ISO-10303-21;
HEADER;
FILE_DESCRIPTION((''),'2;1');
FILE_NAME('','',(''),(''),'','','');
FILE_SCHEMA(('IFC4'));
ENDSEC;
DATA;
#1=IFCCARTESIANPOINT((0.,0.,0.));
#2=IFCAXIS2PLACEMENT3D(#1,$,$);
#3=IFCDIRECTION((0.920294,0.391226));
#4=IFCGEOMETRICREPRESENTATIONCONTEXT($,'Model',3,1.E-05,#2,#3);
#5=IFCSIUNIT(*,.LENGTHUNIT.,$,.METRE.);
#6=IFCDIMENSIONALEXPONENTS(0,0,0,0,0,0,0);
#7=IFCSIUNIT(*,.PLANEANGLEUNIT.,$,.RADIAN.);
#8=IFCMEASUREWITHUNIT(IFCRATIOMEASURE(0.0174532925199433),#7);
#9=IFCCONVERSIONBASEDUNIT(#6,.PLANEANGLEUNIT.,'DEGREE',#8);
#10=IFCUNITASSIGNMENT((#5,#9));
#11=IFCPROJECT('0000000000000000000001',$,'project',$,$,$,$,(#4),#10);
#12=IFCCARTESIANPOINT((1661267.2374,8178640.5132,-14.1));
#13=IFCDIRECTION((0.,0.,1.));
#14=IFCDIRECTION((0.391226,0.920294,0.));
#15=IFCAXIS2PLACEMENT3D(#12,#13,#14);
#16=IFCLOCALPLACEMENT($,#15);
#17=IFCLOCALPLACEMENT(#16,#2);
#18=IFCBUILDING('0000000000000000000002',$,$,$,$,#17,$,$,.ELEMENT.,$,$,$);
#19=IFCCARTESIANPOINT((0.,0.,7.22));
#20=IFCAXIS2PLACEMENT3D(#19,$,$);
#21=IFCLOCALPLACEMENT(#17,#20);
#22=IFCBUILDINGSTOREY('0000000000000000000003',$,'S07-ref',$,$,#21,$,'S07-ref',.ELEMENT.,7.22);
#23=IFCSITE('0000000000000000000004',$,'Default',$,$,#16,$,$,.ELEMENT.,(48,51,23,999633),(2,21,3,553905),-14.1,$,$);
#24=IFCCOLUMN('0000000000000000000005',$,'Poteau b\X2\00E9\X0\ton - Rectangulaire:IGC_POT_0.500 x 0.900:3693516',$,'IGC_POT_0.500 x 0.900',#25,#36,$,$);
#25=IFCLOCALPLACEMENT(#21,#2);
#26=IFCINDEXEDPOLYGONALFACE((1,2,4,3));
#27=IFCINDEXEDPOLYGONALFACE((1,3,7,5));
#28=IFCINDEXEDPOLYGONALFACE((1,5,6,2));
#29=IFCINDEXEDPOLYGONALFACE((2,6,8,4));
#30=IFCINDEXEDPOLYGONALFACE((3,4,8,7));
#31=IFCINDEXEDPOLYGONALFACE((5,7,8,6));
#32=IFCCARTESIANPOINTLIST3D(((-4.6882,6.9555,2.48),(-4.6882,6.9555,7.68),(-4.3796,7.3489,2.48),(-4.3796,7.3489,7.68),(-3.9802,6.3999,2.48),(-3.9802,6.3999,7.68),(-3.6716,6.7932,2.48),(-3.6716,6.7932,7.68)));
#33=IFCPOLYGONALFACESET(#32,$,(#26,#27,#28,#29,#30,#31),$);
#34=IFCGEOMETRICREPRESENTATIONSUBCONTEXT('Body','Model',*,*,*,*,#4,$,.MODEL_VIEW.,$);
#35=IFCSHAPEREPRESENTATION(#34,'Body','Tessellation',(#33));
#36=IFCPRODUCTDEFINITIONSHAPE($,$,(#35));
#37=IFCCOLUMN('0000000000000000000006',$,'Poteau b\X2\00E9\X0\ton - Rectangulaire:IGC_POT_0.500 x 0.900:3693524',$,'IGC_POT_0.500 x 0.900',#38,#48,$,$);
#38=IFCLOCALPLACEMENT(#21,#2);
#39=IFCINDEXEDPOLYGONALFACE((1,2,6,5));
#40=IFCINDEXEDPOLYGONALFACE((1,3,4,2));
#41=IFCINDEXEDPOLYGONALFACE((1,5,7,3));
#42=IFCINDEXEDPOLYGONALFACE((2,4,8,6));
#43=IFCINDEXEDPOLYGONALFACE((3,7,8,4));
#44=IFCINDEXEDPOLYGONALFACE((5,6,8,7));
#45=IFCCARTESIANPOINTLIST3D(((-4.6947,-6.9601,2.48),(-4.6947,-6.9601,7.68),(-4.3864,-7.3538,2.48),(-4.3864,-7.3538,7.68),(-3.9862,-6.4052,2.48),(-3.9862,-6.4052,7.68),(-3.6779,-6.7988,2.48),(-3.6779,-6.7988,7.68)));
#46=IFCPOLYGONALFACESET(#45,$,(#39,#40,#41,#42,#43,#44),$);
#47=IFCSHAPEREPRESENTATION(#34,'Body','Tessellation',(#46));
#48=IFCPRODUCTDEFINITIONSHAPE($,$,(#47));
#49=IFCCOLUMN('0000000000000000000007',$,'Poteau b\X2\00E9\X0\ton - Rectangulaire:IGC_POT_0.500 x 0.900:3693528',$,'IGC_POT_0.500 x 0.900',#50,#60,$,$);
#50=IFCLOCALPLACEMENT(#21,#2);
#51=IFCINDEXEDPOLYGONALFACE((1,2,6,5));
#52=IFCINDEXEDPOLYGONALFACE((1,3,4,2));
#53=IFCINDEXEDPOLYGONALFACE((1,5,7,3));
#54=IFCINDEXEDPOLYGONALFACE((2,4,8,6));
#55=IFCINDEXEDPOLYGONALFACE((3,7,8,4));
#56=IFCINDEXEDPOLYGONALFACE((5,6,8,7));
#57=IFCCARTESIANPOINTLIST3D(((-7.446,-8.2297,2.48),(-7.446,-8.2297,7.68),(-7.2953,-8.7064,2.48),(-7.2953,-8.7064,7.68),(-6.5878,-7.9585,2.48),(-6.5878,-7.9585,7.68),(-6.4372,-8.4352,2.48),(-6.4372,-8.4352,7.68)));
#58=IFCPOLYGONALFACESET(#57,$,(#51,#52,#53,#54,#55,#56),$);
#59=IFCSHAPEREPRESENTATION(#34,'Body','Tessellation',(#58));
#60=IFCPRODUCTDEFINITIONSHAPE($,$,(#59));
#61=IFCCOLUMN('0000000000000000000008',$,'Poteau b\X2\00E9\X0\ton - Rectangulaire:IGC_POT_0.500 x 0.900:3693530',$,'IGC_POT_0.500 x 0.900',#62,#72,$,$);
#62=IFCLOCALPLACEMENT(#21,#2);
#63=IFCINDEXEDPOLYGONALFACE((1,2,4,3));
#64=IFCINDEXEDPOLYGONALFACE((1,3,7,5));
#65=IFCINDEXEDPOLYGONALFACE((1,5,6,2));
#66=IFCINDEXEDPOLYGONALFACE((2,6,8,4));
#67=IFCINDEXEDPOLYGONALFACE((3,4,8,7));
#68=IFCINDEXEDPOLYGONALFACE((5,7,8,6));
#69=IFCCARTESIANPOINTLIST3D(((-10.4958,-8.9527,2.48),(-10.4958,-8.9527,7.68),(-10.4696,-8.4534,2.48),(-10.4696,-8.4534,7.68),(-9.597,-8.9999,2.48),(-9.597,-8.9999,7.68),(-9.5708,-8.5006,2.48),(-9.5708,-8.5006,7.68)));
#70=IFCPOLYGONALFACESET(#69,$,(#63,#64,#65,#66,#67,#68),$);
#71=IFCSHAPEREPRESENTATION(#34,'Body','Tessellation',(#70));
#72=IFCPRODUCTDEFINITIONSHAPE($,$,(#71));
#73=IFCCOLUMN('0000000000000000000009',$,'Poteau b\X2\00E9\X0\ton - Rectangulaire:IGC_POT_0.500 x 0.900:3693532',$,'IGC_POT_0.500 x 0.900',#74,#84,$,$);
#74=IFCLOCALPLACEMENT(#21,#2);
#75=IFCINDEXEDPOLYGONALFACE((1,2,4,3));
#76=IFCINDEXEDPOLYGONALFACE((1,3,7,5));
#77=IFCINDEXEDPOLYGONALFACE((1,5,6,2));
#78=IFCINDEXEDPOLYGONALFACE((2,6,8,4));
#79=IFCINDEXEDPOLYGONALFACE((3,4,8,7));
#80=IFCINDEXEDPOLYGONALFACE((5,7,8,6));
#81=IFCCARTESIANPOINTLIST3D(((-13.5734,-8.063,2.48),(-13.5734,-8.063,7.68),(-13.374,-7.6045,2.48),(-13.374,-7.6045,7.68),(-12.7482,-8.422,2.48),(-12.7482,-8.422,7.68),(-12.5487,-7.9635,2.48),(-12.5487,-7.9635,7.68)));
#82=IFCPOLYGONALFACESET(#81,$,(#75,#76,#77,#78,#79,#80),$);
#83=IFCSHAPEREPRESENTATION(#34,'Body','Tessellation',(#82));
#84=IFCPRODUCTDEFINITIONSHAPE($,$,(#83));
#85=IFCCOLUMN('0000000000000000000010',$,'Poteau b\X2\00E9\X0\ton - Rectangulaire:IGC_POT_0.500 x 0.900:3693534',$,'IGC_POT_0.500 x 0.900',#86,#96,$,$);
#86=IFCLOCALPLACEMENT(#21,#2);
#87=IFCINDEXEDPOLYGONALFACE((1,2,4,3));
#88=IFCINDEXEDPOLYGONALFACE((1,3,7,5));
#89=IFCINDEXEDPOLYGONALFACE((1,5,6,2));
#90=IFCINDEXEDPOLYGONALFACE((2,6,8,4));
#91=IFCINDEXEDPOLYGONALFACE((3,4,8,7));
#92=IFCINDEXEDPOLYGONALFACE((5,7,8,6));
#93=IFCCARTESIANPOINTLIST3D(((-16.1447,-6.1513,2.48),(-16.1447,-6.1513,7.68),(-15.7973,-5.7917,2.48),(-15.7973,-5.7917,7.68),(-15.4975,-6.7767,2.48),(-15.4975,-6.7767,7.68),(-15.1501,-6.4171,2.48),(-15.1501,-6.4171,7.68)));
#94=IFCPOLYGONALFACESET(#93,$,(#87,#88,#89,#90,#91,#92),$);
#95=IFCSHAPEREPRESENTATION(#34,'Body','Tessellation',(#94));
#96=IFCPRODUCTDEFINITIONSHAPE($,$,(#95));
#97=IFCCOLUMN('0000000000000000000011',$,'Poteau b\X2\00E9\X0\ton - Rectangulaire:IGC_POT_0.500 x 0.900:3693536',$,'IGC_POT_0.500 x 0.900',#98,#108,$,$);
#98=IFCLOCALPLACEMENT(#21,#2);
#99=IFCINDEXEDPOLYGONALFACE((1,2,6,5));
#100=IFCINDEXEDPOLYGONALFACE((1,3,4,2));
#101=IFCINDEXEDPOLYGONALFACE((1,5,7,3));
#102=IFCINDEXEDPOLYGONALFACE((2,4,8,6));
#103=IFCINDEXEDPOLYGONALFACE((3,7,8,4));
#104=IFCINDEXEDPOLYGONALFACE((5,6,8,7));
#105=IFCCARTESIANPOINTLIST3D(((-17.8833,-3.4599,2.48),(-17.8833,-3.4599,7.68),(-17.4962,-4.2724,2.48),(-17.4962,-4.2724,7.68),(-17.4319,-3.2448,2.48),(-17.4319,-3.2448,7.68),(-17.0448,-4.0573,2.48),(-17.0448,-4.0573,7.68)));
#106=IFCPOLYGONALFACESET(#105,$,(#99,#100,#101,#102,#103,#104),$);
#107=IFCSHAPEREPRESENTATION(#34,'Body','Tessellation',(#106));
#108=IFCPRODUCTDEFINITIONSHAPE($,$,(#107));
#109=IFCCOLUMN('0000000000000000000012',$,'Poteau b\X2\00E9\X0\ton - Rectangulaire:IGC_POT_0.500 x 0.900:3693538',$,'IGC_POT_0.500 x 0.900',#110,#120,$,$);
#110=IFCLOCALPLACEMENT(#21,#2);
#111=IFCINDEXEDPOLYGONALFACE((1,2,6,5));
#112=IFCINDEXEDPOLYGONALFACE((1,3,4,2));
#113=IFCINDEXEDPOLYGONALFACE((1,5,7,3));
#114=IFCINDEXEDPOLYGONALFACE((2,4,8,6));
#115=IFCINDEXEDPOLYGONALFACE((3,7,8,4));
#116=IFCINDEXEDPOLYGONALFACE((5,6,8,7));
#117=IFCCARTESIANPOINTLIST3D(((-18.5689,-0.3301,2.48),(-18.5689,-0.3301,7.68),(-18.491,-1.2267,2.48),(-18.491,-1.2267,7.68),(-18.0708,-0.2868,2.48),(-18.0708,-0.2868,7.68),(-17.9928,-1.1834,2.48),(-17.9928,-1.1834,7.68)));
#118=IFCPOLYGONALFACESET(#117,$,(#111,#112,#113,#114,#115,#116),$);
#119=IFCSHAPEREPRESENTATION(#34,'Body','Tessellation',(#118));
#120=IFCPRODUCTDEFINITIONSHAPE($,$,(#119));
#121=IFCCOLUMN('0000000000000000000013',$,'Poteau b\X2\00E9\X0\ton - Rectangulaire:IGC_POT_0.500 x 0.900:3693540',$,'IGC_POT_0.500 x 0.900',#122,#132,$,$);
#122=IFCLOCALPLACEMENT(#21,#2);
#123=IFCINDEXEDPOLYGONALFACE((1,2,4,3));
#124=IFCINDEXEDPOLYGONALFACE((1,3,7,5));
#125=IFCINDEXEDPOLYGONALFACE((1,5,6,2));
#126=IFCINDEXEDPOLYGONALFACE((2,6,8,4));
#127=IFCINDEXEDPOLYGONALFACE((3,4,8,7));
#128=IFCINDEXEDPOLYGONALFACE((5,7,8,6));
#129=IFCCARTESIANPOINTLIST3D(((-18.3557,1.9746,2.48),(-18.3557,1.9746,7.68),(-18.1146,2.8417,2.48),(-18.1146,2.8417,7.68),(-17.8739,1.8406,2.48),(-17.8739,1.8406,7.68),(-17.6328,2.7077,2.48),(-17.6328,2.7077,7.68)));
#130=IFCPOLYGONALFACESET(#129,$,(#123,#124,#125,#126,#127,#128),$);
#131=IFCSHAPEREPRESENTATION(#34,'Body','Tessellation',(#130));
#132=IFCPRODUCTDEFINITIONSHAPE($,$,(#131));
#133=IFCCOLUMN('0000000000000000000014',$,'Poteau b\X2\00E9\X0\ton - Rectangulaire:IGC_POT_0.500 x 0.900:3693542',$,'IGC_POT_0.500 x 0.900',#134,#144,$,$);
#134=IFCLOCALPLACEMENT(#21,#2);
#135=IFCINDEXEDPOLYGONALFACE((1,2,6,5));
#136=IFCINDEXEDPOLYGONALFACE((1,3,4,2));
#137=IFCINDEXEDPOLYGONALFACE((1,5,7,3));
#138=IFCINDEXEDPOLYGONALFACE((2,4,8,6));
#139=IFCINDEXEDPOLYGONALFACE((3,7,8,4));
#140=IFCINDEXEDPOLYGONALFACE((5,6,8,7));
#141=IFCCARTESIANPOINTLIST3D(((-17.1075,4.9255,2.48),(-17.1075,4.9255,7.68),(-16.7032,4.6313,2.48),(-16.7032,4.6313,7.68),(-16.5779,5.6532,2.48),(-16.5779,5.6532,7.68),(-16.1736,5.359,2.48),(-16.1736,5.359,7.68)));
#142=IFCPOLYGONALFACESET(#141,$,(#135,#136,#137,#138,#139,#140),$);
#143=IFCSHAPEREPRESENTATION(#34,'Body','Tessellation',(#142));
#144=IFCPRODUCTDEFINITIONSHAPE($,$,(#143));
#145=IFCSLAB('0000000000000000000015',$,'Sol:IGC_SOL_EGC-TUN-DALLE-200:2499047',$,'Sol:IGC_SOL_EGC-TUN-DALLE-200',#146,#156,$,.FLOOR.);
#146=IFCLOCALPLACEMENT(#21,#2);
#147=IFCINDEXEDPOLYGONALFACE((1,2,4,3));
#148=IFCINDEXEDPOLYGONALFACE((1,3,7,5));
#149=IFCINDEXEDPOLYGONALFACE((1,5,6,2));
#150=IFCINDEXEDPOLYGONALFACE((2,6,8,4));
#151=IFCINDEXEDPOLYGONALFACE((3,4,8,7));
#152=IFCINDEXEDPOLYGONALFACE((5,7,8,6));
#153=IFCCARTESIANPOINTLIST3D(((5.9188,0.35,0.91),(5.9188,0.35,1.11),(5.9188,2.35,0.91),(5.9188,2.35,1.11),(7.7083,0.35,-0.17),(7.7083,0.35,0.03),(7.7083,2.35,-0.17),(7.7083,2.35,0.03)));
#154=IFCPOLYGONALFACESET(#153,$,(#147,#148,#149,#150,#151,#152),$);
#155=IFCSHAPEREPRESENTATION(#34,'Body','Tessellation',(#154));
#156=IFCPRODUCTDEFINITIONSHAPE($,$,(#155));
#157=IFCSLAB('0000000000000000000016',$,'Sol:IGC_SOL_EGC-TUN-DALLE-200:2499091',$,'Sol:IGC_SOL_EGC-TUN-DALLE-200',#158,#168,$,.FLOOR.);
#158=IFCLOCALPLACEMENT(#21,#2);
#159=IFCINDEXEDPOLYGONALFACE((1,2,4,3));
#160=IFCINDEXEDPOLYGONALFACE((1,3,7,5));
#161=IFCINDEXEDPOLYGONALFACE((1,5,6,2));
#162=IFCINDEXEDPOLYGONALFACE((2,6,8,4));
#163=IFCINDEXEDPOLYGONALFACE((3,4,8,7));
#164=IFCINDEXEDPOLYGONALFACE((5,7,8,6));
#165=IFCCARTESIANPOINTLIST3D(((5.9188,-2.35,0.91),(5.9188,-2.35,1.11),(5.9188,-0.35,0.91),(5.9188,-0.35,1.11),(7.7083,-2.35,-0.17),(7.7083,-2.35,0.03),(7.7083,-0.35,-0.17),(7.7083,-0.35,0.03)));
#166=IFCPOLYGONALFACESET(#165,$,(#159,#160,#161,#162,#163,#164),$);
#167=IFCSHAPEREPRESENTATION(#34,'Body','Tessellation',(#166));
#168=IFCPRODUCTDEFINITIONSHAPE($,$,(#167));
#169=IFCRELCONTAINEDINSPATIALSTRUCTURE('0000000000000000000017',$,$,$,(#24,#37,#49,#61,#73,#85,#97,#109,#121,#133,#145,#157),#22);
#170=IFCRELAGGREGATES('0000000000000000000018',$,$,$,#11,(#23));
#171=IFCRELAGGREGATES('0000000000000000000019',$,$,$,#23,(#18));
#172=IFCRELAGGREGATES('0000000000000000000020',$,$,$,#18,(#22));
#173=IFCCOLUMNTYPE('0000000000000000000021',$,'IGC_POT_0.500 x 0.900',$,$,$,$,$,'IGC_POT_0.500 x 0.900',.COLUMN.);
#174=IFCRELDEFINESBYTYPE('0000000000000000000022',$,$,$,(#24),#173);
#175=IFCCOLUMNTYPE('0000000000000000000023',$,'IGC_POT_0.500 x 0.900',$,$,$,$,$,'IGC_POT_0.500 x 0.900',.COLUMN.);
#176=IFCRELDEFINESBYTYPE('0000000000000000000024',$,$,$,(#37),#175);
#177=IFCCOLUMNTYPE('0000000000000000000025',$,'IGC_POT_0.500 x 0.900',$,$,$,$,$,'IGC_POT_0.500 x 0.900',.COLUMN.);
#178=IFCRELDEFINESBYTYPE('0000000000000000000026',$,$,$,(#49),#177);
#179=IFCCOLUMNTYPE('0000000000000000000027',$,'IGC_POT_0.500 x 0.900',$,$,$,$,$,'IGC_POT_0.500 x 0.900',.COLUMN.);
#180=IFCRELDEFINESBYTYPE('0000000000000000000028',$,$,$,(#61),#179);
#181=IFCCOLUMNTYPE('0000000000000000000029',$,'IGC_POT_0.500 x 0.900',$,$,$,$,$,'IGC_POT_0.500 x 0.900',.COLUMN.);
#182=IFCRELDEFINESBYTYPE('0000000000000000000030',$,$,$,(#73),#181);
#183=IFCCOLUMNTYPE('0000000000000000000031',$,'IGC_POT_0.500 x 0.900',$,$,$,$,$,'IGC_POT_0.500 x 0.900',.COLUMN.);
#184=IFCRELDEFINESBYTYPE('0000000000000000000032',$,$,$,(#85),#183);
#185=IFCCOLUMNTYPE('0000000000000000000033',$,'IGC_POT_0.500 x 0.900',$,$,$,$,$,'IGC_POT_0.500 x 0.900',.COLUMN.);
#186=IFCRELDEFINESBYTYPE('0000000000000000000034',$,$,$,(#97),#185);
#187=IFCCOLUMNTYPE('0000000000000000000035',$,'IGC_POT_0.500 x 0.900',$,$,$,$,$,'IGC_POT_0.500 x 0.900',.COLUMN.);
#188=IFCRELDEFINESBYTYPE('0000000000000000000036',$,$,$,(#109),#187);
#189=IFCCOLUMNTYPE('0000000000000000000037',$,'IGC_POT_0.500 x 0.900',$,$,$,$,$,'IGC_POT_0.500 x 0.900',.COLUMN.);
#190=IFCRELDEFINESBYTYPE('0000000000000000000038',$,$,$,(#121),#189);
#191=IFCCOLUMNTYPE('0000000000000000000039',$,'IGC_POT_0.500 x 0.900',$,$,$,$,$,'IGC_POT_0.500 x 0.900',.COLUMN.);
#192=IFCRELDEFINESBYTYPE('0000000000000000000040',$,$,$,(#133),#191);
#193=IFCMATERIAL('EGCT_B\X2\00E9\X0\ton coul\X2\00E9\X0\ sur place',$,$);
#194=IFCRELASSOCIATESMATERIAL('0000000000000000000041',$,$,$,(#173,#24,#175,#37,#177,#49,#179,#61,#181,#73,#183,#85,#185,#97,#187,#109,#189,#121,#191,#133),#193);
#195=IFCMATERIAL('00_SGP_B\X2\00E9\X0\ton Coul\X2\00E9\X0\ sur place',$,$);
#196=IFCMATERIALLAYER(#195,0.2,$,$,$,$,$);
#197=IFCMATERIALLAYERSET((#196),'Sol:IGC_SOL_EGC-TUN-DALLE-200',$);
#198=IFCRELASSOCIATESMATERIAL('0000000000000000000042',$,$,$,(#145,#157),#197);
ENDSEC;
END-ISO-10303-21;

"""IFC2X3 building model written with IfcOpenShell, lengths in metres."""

from ifc_helpers import new_model, entity, si_unit, converted_unit, direction, frame, frame_2d, origin, origin_2d_with_axis, place, context, subcontext, project, spatial, polyline, rectangle, outline, extrude, source, transform, mapped, material, layer, layer_set, layer_usage, type_object, type_shapes, element, save


model = new_model("IFC2X3")

# Units and contexts
model_context = context("Model", 3, precision=1e-05, world=origin(), true_north=direction((0.920294, 0.391226)))
body_context = subcontext(model_context, "Body", "Model", "MODEL_VIEW")
ifc_project = project(units=[si_unit("LENGTHUNIT", "METRE"), converted_unit("PLANEANGLEUNIT", "DEGREE", entity("IfcRatioMeasure", 0.0174532925199433), si_unit("PLANEANGLEUNIT", "RADIAN"), dimensions=[0, 0, 0, 0, 0, 0, 0])], contexts=[model_context])

# Site, building, storey
site_placement = place(None, frame((1661267.2374, 8178640.5132, -14.1), z_axis=(0.0, 0.0, 1.0), x_axis=(0.391226, 0.920294, 0.0)))
site = spatial("IfcSite", under=ifc_project, at=site_placement, Name="Default", CompositionType="ELEMENT", RefLatitude=(48, 51, 23, 999633), RefLongitude=(2, 21, 3, 553905), RefElevation=-14.1)
building_placement = place(site_placement, origin())
building = spatial("IfcBuilding", under=site, at=building_placement, CompositionType="ELEMENT")
storey_placement = place(building_placement, frame((0.0, 0.0, 7.22)))
storey = spatial("IfcBuildingStorey", under=building, at=storey_placement, Name="S07-ref", LongName="S07-ref", CompositionType="ELEMENT", Elevation=7.22)

# Columns
ifc_material_1 = material(Name="EGCT_Béton coulé sur place")
column_type_1 = type_object("IfcColumnType", Name="IGC_POT_0.500 x 0.900", ElementType="IGC_POT_0.500 x 0.900", PredefinedType="COLUMN", material=ifc_material_1)
shared_shape_1 = source(origin(), body_context, "Body", "SweptSolid", [
    extrude(rectangle(XDim=0.9, YDim=0.5, at=frame_2d((0.0, 0.0), x_axis=(1.0, 0.0))), frame((-4.1799, 6.8744, 9.7), z_axis=(0.0, 0.0, 1.0), x_axis=(-0.786665, 0.617381, 0.0)), (0.0, 0.0, 1.0), 5.2),
])
type_shapes(column_type_1, [shared_shape_1])
column_1_placement = place(storey_placement, frame((0.0, 0.0, -7.22)))
element("IfcColumn", 1, at=column_1_placement, inside=storey, type_object=column_type_1, material=ifc_material_1, Name="Poteau béton - Rectangulaire:IGC_POT_0.500 x 0.900:3693516", ObjectType="IGC_POT_0.500 x 0.900", context=body_context, shape_type="MappedRepresentation", body=[
    mapped(shared_shape_1, transform((0.0, 0.0, 0.0), scale=1.0)),
])
column_type_2 = type_object("IfcColumnType", Name="IGC_POT_0.500 x 0.900", ElementType="IGC_POT_0.500 x 0.900", PredefinedType="COLUMN", material=ifc_material_1)
shared_shape_2 = source(origin(), body_context, "Body", "SweptSolid", [
    extrude(rectangle(XDim=0.9, YDim=0.5, at=origin_2d_with_axis()), frame((-4.1863, -6.8795, 9.7), z_axis=(0.0, 0.0, 1.0), x_axis=(0.787239, 0.616648, 0.0)), (0.0, 0.0, 1.0), 5.2),
])
type_shapes(column_type_2, [shared_shape_2])
column_2_placement = place(storey_placement, frame((0.0, 0.0, -7.22)))
element("IfcColumn", 2, at=column_2_placement, inside=storey, type_object=column_type_2, material=ifc_material_1, Name="Poteau béton - Rectangulaire:IGC_POT_0.500 x 0.900:3693524", ObjectType="IGC_POT_0.500 x 0.900", context=body_context, shape_type="MappedRepresentation", body=[
    mapped(shared_shape_2, transform((0.0, 0.0, 0.0), scale=1.0)),
])
column_type_3 = type_object("IfcColumnType", Name="IGC_POT_0.500 x 0.900", ElementType="IGC_POT_0.500 x 0.900", PredefinedType="COLUMN", material=ifc_material_1)
shared_shape_3 = source(origin(), body_context, "Body", "SweptSolid", [
    extrude(rectangle(XDim=0.5, YDim=0.9, at=origin_2d_with_axis()), frame((-6.9416, -8.3325, 9.7), z_axis=(0.0, 0.0, 1.0), x_axis=(-0.301353, 0.953513, 0.0)), (0.0, 0.0, 1.0), 5.2),
])
type_shapes(column_type_3, [shared_shape_3])
column_3_placement = place(storey_placement, frame((0.0, 0.0, -7.22)))
element("IfcColumn", 3, at=column_3_placement, inside=storey, type_object=column_type_3, material=ifc_material_1, Name="Poteau béton - Rectangulaire:IGC_POT_0.500 x 0.900:3693528", ObjectType="IGC_POT_0.500 x 0.900", context=body_context, shape_type="MappedRepresentation", body=[
    mapped(shared_shape_3, transform((0.0, 0.0, 0.0), scale=1.0)),
])
column_type_4 = type_object("IfcColumnType", Name="IGC_POT_0.500 x 0.900", ElementType="IGC_POT_0.500 x 0.900", PredefinedType="COLUMN", material=ifc_material_1)
shared_shape_4 = source(origin(), body_context, "Body", "SweptSolid", [
    extrude(rectangle(XDim=0.5, YDim=0.9, at=frame_2d((0.0, 0.0), x_axis=(1.0, 0.0))), frame((-10.0333, -8.7267, 9.7), z_axis=(0.0, 0.0, 1.0), x_axis=(0.052447, 0.998624, 0.0)), (0.0, 0.0, 1.0), 5.2),
])
type_shapes(column_type_4, [shared_shape_4])
column_4_placement = place(storey_placement, frame((0.0, 0.0, -7.22)))
element("IfcColumn", 4, at=column_4_placement, inside=storey, type_object=column_type_4, material=ifc_material_1, Name="Poteau béton - Rectangulaire:IGC_POT_0.500 x 0.900:3693530", ObjectType="IGC_POT_0.500 x 0.900", context=body_context, shape_type="MappedRepresentation", body=[
    mapped(shared_shape_4, transform((0.0, 0.0, 0.0), scale=1.0)),
])
column_type_5 = type_object("IfcColumnType", Name="IGC_POT_0.500 x 0.900", ElementType="IGC_POT_0.500 x 0.900", PredefinedType="COLUMN", material=ifc_material_1)
shared_shape_5 = source(origin(), body_context, "Body", "SweptSolid", [
    extrude(rectangle(XDim=0.9, YDim=0.5, at=frame_2d((0.0, 0.0), x_axis=(1.0, 0.0))), frame((-13.0611, -8.0132, 9.7), z_axis=(0.0, 0.0, 1.0), x_axis=(-0.916984, 0.398923, 0.0)), (0.0, 0.0, 1.0), 5.2),
])
type_shapes(column_type_5, [shared_shape_5])
column_5_placement = place(storey_placement, frame((0.0, 0.0, -7.22)))
element("IfcColumn", 5, at=column_5_placement, inside=storey, type_object=column_type_5, material=ifc_material_1, Name="Poteau béton - Rectangulaire:IGC_POT_0.500 x 0.900:3693532", ObjectType="IGC_POT_0.500 x 0.900", context=body_context, shape_type="MappedRepresentation", body=[
    mapped(shared_shape_5, transform((0.0, 0.0, 0.0), scale=1.0)),
])
column_type_6 = type_object("IfcColumnType", Name="IGC_POT_0.500 x 0.900", ElementType="IGC_POT_0.500 x 0.900", PredefinedType="COLUMN", material=ifc_material_1)
shared_shape_6 = source(origin(), body_context, "Body", "SweptSolid", [
    extrude(rectangle(XDim=0.9, YDim=0.5, at=origin_2d_with_axis()), frame((-15.6474, -6.2842, 9.7), z_axis=(0.0, 0.0, 1.0), x_axis=(-0.719121, 0.694885, 0.0)), (0.0, 0.0, 1.0), 5.2),
])
type_shapes(column_type_6, [shared_shape_6])
column_6_placement = place(storey_placement, frame((0.0, 0.0, -7.22)))
element("IfcColumn", 6, at=column_6_placement, inside=storey, type_object=column_type_6, material=ifc_material_1, Name="Poteau béton - Rectangulaire:IGC_POT_0.500 x 0.900:3693534", ObjectType="IGC_POT_0.500 x 0.900", context=body_context, shape_type="MappedRepresentation", body=[
    mapped(shared_shape_6, transform((0.0, 0.0, 0.0), scale=1.0)),
])
column_type_7 = type_object("IfcColumnType", Name="IGC_POT_0.500 x 0.900", ElementType="IGC_POT_0.500 x 0.900", PredefinedType="COLUMN", material=ifc_material_1)
shared_shape_7 = source(origin(), body_context, "Body", "SweptSolid", [
    extrude(rectangle(XDim=0.9, YDim=0.5, at=frame_2d((0.0, 0.0), x_axis=(1.0, 0.0))), frame((-17.4641, -3.7586, 9.7), z_axis=(0.0, 0.0, 1.0), x_axis=(-0.430108, 0.902777, 0.0)), (0.0, 0.0, 1.0), 5.2),
])
type_shapes(column_type_7, [shared_shape_7])
column_7_placement = place(storey_placement, frame((0.0, 0.0, -7.22)))
element("IfcColumn", 7, at=column_7_placement, inside=storey, type_object=column_type_7, material=ifc_material_1, Name="Poteau béton - Rectangulaire:IGC_POT_0.500 x 0.900:3693536", ObjectType="IGC_POT_0.500 x 0.900", context=body_context, shape_type="MappedRepresentation", body=[
    mapped(shared_shape_7, transform((0.0, 0.0, 0.0), scale=1.0)),
])
column_type_8 = type_object("IfcColumnType", Name="IGC_POT_0.500 x 0.900", ElementType="IGC_POT_0.500 x 0.900", PredefinedType="COLUMN", material=ifc_material_1)
shared_shape_8 = source(origin(), body_context, "Body", "SweptSolid", [
    extrude(rectangle(XDim=0.9, YDim=0.5, at=frame_2d((0.0, 0.0), x_axis=(1.0, 0.0))), frame((-18.2809, -0.7567, 9.7), z_axis=(0.0, 0.0, 1.0), x_axis=(-0.086594, 0.996244, 0.0)), (0.0, 0.0, 1.0), 5.2),
])
type_shapes(column_type_8, [shared_shape_8])
column_8_placement = place(storey_placement, frame((0.0, 0.0, -7.22)))
element("IfcColumn", 8, at=column_8_placement, inside=storey, type_object=column_type_8, material=ifc_material_1, Name="Poteau béton - Rectangulaire:IGC_POT_0.500 x 0.900:3693538", ObjectType="IGC_POT_0.500 x 0.900", context=body_context, shape_type="MappedRepresentation", body=[
    mapped(shared_shape_8, transform((0.0, 0.0, 0.0), scale=1.0)),
])
column_type_9 = type_object("IfcColumnType", Name="IGC_POT_0.500 x 0.900", ElementType="IGC_POT_0.500 x 0.900", PredefinedType="COLUMN", material=ifc_material_1)
shared_shape_9 = source(origin(), body_context, "Body", "SweptSolid", [
    extrude(rectangle(XDim=0.5, YDim=0.9, at=frame_2d((0.0, 0.0), x_axis=(1.0, 0.0))), frame((-17.9943, 2.3411, 9.7), z_axis=(0.0, 0.0, 1.0), x_axis=(-0.963446, 0.267904, 0.0)), (0.0, 0.0, 1.0), 5.2),
])
type_shapes(column_type_9, [shared_shape_9])
column_9_placement = place(storey_placement, frame((0.0, 0.0, -7.22)))
element("IfcColumn", 9, at=column_9_placement, inside=storey, type_object=column_type_9, material=ifc_material_1, Name="Poteau béton - Rectangulaire:IGC_POT_0.500 x 0.900:3693540", ObjectType="IGC_POT_0.500 x 0.900", context=body_context, shape_type="MappedRepresentation", body=[
    mapped(shared_shape_9, transform((0.0, 0.0, 0.0), scale=1.0)),
])
column_type_10 = type_object("IfcColumnType", Name="IGC_POT_0.500 x 0.900", ElementType="IGC_POT_0.500 x 0.900", PredefinedType="COLUMN", material=ifc_material_1)
shared_shape_10 = source(origin(), body_context, "Body", "SweptSolid", [
    extrude(rectangle(XDim=0.5, YDim=0.9, at=frame_2d((0.0, 0.0), x_axis=(1.0, 0.0))), frame((-16.6405, 5.1423, 9.7), z_axis=(0.0, 0.0, 1.0), x_axis=(-0.808536, 0.588447, 0.0)), (0.0, 0.0, 1.0), 5.2),
])
type_shapes(column_type_10, [shared_shape_10])
column_10_placement = place(storey_placement, frame((0.0, 0.0, -7.22)))
element("IfcColumn", 10, at=column_10_placement, inside=storey, type_object=column_type_10, material=ifc_material_1, Name="Poteau béton - Rectangulaire:IGC_POT_0.500 x 0.900:3693542", ObjectType="IGC_POT_0.500 x 0.900", context=body_context, shape_type="MappedRepresentation", body=[
    mapped(shared_shape_10, transform((0.0, 0.0, 0.0), scale=1.0)),
])

# Slabs
ifc_material_2 = material(Name="00_SGP_Béton Coulé sur place")
ifc_layer_1 = layer(ifc_material_2, 0.2)
ifc_layer_set_1 = layer_set([ifc_layer_1], Name="Sol:IGC_SOL_EGC-TUN-DALLE-200")
ifc_layer_usage_1 = layer_usage(ifc_layer_set_1, "AXIS3", "POSITIVE", 0.0)
slab_1_placement = place(storey_placement, frame((5.9188, 0.35, -0.17)))
element("IfcSlab", 11, at=slab_1_placement, inside=storey, material=ifc_layer_usage_1, Name="Sol:IGC_SOL_EGC-TUN-DALLE-200:2499047", ObjectType="Sol:IGC_SOL_EGC-TUN-DALLE-200", PredefinedType="FLOOR", context=body_context, shape_type="SweptSolid", body=[
    extrude(outline(polyline([(-1.0451, -1.0), (1.0451, -1.0), (1.0451, 1.0), (-1.0451, 1.0), (-1.0451, -1.0)])), frame((0.8948, 1.0, 0.74), z_axis=(0.516703, 0.0, 0.856165), x_axis=(0.856165, 0.0, -0.516703)), (0.516703, 0.0, -0.856165), 0.2),
])
ifc_layer_usage_2 = layer_usage(ifc_layer_set_1, "AXIS3", "POSITIVE", 0.0)
slab_2_placement = place(storey_placement, frame((5.9188, -2.35, -0.17)))
element("IfcSlab", 12, at=slab_2_placement, inside=storey, material=ifc_layer_usage_2, Name="Sol:IGC_SOL_EGC-TUN-DALLE-200:2499091", ObjectType="Sol:IGC_SOL_EGC-TUN-DALLE-200", PredefinedType="FLOOR", context=body_context, shape_type="SweptSolid", body=[
    extrude(outline(polyline([(-1.0451, -1.0), (1.0451, -1.0), (1.0451, 1.0), (-1.0451, 1.0), (-1.0451, -1.0)])), frame((0.8948, 1.0, 0.74), z_axis=(0.516703, 0.0, 0.856165), x_axis=(0.856165, 0.0, -0.516703)), (0.516703, 0.0, -0.856165), 0.2),
])

save(model, "model.ifc")
